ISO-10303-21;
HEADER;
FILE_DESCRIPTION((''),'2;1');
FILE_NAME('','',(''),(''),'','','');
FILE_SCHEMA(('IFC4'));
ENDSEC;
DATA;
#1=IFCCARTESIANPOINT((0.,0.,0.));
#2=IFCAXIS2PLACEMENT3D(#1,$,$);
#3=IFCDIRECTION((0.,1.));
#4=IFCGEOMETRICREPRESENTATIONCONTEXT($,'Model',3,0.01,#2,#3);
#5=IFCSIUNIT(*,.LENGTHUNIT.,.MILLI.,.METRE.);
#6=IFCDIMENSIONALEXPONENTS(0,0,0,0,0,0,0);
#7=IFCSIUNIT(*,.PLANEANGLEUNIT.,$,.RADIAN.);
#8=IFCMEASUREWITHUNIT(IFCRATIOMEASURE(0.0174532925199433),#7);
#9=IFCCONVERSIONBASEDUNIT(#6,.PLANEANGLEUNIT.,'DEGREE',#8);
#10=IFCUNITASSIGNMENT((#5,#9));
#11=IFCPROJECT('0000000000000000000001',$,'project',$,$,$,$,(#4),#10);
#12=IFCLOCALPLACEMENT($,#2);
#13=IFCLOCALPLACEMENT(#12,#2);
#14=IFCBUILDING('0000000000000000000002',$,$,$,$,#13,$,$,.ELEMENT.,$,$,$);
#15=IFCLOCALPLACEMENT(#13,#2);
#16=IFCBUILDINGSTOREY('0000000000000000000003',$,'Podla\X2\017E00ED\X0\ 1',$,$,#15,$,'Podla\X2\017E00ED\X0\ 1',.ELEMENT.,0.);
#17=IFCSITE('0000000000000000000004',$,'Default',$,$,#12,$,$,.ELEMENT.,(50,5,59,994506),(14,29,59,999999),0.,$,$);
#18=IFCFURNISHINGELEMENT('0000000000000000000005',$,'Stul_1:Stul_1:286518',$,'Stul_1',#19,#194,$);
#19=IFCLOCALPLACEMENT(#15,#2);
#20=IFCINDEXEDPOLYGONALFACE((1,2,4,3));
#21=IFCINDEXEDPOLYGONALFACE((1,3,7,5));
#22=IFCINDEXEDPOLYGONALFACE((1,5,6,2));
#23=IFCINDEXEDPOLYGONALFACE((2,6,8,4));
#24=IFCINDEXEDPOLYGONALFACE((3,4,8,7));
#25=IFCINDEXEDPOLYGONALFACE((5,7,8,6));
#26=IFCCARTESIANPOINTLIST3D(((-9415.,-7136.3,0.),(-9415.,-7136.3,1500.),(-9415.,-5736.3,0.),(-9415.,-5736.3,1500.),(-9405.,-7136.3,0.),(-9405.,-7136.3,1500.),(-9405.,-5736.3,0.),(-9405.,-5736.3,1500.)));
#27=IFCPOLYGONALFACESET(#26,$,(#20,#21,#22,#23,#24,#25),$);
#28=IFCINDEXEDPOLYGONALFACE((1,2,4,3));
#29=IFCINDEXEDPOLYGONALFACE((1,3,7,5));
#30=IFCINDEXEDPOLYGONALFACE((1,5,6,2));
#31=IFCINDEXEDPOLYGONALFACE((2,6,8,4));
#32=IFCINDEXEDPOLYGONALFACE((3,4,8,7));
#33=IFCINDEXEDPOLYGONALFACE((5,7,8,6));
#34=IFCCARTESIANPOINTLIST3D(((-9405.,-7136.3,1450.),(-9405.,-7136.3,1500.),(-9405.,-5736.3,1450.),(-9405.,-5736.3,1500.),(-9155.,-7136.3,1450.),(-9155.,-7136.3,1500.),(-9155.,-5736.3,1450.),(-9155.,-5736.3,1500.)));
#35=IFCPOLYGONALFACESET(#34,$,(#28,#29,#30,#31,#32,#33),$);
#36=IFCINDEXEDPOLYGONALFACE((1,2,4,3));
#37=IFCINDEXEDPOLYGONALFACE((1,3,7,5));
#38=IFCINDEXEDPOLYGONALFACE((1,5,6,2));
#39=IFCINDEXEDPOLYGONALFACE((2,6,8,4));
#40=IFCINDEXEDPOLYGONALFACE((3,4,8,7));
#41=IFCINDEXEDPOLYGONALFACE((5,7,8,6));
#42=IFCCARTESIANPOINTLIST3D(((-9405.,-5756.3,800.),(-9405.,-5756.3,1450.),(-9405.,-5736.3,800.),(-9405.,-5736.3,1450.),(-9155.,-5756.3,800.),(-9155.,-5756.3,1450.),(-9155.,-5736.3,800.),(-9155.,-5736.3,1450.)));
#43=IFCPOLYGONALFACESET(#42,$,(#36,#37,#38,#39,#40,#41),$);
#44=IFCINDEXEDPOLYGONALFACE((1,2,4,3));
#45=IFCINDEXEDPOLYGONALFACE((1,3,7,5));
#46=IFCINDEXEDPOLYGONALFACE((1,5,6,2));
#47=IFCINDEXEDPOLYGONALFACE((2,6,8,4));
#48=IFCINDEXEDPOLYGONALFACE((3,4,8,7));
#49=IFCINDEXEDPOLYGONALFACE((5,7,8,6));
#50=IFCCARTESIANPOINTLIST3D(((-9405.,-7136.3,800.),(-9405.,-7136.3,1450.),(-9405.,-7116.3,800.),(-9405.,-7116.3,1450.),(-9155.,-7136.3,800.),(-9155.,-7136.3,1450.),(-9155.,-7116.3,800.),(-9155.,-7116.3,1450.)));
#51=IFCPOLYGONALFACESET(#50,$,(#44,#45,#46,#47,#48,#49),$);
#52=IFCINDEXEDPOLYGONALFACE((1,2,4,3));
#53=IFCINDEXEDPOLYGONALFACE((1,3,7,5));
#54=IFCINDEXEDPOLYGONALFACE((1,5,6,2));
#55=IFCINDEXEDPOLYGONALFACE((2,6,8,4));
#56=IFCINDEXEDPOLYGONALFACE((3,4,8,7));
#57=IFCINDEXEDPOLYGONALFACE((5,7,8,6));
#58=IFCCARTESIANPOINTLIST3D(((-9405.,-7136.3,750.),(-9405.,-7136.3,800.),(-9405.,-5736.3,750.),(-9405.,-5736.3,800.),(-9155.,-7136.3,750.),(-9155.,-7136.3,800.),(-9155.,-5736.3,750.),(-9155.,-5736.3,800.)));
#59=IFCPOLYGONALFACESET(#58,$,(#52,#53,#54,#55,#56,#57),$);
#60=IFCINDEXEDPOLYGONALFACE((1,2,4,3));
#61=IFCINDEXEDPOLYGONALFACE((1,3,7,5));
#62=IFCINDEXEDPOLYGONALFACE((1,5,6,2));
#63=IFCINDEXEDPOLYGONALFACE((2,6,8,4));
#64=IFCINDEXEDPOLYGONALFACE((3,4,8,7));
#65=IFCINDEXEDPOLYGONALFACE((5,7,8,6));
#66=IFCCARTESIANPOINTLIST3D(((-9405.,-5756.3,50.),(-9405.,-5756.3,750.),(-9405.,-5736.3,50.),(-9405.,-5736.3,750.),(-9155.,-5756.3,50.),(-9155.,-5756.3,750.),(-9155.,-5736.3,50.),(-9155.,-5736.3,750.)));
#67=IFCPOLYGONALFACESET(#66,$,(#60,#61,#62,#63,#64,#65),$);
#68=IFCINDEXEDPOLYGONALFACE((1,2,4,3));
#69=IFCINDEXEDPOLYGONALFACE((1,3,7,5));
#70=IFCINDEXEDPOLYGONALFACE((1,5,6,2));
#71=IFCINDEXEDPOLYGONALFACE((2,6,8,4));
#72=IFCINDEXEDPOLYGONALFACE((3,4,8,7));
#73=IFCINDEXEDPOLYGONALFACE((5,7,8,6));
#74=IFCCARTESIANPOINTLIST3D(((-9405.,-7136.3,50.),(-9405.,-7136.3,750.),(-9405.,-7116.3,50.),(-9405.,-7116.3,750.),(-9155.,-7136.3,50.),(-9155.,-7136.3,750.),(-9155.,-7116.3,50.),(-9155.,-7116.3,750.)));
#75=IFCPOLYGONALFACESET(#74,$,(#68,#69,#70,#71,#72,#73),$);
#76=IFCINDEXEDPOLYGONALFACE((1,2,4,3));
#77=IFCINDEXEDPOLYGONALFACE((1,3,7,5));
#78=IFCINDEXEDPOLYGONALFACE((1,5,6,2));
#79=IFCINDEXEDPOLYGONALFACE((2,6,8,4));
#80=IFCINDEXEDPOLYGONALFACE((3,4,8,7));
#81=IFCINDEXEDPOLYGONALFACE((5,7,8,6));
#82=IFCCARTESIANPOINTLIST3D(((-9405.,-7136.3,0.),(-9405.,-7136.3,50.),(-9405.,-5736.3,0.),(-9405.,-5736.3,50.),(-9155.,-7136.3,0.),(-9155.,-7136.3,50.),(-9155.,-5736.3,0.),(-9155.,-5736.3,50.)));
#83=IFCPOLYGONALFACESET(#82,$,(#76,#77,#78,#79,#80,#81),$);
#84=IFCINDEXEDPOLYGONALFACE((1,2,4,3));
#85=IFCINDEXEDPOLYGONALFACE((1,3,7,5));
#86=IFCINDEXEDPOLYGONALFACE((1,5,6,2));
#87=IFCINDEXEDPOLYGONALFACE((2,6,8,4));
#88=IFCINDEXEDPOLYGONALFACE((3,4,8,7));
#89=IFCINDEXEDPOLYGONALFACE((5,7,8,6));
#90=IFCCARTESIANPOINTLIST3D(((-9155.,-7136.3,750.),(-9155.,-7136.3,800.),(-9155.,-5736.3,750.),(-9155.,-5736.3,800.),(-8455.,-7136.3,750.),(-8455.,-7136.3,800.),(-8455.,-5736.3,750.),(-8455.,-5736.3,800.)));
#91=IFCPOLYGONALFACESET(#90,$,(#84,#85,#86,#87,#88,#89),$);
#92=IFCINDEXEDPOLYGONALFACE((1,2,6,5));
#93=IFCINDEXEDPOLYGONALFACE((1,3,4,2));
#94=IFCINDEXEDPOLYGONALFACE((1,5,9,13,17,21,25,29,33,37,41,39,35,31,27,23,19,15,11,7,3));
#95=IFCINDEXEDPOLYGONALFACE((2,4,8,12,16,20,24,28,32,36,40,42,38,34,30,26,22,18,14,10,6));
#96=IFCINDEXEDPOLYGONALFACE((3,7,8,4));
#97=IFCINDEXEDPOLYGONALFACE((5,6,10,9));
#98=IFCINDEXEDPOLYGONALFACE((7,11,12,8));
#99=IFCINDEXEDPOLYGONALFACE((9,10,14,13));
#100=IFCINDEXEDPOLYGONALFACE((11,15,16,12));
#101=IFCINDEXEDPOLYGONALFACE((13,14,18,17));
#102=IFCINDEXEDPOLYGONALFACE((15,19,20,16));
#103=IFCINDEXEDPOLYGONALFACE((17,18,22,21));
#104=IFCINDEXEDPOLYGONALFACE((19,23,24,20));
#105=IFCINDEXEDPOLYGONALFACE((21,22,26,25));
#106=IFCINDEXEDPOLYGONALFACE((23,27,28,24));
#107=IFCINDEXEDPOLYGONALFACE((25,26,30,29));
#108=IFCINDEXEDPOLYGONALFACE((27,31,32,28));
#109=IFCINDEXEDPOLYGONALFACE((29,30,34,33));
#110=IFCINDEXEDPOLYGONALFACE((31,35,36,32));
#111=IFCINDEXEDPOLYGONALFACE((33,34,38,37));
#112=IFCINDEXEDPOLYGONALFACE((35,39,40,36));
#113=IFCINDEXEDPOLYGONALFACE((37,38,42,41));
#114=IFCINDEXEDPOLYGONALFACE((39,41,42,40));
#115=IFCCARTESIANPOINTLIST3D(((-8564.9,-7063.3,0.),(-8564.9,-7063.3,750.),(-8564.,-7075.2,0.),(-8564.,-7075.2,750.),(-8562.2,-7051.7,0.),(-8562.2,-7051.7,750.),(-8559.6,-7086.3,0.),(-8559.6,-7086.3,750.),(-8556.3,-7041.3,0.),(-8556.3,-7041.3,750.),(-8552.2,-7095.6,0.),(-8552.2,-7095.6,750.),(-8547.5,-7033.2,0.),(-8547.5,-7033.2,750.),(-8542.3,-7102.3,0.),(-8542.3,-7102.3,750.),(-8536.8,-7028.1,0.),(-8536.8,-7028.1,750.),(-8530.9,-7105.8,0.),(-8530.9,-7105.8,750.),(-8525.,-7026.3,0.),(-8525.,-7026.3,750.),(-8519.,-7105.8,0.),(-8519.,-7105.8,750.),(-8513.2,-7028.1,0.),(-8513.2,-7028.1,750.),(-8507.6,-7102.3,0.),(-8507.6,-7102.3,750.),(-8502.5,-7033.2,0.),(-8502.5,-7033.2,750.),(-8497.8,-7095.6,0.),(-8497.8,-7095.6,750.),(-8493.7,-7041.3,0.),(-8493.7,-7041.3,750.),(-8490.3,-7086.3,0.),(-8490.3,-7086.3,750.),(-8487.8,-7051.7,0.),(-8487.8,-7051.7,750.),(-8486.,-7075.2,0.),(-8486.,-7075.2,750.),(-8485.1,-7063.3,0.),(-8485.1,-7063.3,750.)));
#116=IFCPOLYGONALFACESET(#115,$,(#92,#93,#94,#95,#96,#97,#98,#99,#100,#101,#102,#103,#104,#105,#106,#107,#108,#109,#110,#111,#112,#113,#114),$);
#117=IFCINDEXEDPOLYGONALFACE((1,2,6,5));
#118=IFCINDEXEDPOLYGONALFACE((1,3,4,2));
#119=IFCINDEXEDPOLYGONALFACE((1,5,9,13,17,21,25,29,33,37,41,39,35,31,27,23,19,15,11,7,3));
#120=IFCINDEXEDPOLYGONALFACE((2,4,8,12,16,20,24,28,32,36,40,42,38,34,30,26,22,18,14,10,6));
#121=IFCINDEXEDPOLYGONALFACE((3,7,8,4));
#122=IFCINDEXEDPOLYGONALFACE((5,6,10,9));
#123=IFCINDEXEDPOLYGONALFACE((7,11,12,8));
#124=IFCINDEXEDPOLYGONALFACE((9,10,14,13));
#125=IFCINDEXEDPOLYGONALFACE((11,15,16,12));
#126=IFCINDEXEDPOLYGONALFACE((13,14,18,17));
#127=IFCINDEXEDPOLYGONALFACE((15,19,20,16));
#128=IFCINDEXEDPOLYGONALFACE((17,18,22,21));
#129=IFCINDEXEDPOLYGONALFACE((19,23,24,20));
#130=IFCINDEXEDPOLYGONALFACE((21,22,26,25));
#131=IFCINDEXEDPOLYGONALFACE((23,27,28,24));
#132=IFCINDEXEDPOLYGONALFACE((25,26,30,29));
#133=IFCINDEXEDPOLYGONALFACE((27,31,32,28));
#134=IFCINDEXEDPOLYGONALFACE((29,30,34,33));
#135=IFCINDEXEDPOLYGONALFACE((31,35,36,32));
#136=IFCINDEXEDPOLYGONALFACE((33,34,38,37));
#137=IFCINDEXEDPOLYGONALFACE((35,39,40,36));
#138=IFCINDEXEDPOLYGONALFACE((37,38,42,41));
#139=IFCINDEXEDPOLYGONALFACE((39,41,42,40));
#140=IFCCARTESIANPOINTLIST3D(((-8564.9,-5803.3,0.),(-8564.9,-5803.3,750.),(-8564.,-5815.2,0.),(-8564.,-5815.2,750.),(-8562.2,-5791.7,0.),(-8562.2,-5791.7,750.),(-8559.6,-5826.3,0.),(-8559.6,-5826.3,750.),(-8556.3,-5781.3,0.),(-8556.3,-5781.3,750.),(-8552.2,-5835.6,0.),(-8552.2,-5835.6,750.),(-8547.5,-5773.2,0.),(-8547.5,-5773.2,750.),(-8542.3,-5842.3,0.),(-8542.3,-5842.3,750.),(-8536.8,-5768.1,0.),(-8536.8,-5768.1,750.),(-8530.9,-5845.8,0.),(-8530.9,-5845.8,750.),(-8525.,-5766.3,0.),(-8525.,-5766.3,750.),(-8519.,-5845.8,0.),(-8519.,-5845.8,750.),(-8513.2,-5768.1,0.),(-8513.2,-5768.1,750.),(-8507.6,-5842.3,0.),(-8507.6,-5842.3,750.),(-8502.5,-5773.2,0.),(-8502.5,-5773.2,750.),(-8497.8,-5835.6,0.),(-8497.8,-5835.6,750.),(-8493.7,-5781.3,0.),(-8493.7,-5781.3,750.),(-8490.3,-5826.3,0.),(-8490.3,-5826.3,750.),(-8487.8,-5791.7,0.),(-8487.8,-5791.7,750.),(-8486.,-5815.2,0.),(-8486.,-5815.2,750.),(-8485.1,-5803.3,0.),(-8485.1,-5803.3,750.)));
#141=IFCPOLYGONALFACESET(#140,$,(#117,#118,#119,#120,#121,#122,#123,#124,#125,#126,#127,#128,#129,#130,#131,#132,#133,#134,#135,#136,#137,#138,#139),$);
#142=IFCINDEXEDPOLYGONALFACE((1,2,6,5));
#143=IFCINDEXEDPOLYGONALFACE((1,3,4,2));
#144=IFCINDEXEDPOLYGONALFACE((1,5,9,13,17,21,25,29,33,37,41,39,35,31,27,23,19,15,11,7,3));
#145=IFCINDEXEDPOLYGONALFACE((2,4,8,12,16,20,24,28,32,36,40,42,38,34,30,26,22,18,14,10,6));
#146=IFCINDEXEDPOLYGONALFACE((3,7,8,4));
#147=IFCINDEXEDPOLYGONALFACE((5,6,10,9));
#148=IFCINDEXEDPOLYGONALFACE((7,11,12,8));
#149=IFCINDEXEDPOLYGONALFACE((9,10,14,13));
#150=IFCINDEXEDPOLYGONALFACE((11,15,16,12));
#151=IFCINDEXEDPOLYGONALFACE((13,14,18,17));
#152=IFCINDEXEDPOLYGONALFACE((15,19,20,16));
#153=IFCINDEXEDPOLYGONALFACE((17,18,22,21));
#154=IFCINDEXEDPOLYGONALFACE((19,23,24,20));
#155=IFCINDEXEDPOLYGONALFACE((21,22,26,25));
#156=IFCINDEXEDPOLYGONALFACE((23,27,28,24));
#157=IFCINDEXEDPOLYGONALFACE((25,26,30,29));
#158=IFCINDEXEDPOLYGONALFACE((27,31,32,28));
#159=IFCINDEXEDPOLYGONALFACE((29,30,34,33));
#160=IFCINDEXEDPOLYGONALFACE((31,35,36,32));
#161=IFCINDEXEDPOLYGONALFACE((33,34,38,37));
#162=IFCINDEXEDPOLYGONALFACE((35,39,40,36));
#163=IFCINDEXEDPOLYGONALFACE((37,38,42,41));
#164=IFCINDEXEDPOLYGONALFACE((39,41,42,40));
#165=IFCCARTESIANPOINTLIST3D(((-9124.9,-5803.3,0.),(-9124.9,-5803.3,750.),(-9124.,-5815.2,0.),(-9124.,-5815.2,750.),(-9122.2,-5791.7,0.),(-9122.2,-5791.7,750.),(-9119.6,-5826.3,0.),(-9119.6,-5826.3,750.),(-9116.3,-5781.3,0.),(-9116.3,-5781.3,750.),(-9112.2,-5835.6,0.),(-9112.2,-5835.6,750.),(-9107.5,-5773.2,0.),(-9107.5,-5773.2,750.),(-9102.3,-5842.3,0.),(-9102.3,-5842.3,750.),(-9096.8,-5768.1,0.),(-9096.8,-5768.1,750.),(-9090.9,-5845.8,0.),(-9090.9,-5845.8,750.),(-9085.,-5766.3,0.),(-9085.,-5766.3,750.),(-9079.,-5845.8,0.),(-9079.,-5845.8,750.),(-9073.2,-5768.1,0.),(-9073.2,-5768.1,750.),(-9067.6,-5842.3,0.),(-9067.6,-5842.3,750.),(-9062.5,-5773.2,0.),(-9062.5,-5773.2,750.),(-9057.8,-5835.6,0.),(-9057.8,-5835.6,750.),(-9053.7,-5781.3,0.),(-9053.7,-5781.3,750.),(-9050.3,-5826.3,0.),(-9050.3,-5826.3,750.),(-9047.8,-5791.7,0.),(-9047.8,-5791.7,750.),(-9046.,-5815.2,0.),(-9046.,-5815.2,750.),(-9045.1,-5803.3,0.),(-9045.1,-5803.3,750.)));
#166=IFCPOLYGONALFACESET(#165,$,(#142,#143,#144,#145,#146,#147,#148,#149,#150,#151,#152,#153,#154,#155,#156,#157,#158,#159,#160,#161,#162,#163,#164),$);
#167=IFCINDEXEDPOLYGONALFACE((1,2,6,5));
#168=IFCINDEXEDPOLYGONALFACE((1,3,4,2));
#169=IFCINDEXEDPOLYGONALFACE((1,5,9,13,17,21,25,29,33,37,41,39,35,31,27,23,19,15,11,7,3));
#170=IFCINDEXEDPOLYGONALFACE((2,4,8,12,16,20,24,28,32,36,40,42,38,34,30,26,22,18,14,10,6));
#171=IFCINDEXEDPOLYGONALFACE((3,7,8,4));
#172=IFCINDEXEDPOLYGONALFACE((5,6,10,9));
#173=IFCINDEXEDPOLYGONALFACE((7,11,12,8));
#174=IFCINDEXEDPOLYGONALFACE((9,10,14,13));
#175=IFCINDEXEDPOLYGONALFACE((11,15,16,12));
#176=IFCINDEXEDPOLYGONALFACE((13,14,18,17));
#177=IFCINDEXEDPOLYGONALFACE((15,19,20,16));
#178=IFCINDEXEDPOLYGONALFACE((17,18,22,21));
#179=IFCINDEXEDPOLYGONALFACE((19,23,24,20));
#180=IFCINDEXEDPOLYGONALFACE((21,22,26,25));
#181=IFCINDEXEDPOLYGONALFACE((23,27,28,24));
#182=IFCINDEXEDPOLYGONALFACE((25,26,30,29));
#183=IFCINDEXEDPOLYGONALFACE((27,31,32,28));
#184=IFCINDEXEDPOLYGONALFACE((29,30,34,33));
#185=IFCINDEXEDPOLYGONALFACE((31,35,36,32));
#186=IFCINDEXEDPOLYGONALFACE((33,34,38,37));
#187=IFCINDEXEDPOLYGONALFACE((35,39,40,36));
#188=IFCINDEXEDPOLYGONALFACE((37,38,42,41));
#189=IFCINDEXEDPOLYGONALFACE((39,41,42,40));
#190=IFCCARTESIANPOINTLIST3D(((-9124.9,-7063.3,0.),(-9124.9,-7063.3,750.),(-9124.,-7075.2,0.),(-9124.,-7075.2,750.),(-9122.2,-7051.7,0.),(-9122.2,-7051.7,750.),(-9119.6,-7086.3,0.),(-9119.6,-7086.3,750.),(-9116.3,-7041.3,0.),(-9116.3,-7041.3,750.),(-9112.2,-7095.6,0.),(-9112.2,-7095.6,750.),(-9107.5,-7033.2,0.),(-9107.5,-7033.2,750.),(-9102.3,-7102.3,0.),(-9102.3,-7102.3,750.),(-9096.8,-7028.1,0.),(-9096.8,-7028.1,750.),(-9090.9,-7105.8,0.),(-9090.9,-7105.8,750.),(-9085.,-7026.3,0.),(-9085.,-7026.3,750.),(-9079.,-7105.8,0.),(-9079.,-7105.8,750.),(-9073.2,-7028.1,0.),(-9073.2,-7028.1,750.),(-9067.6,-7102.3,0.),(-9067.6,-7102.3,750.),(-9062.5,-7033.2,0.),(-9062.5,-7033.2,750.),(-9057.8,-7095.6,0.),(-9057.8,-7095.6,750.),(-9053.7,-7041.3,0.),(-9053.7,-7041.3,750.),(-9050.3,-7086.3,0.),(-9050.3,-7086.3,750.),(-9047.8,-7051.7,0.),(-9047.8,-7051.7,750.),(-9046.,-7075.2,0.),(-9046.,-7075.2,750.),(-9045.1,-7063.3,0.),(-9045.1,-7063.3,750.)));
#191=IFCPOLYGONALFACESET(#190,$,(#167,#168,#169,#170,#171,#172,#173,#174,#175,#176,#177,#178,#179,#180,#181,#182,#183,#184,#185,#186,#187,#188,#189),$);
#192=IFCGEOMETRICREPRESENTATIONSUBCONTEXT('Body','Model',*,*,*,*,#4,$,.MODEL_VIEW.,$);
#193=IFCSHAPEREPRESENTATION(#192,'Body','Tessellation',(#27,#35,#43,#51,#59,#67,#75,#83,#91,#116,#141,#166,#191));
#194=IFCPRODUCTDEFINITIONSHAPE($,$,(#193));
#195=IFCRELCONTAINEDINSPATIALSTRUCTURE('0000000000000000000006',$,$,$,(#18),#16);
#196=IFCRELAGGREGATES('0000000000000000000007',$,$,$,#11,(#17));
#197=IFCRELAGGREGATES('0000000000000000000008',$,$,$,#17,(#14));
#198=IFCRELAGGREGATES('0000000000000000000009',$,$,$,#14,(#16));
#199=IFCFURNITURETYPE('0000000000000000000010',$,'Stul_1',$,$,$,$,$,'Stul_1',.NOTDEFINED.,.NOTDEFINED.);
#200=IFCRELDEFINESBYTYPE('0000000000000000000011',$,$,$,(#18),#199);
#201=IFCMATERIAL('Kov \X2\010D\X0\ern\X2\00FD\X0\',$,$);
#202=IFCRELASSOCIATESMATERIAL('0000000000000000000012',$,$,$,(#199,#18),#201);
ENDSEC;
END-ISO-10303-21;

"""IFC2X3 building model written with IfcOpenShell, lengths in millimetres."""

from ifc_helpers import new_model, entity, si_unit, converted_unit, direction, frame, frame_2d, origin, origin_2d_with_axis, place, context, subcontext, project, spatial, rectangle, circle, extrude, source, transform, mapped, material, type_object, type_shapes, element, save


model = new_model("IFC2X3")

# Units and contexts
model_context = context("Model", 3, precision=0.01, world=origin(), true_north=direction((0.0, 1.0)))
body_context = subcontext(model_context, "Body", "Model", "MODEL_VIEW")
ifc_project = project(units=[si_unit("LENGTHUNIT", "METRE", prefix="MILLI"), converted_unit("PLANEANGLEUNIT", "DEGREE", entity("IfcRatioMeasure", 0.0174532925199433), si_unit("PLANEANGLEUNIT", "RADIAN"), dimensions=[0, 0, 0, 0, 0, 0, 0])], contexts=[model_context])

# Site, building, storey
site_placement = place(None, origin())
site = spatial("IfcSite", under=ifc_project, at=site_placement, Name="Default", CompositionType="ELEMENT", RefLatitude=(50, 5, 59, 994506), RefLongitude=(14, 29, 59, 999999), RefElevation=0.0)
building_placement = place(site_placement, origin())
building = spatial("IfcBuilding", under=site, at=building_placement, CompositionType="ELEMENT")
storey_placement = place(building_placement, origin())
storey = spatial("IfcBuildingStorey", under=building, at=storey_placement, Name="Podlaží 1", LongName="Podlaží 1", CompositionType="ELEMENT", Elevation=0.0)

# Furnishing element
ifc_material_1 = material(Name="Kov černý")
furniture_type = type_object("IfcFurnitureType", Name="Stul_1", ElementType="Stul_1", material=ifc_material_1)
shared_shape_1 = source(origin(), body_context, "Body", "SweptSolid", [
    extrude(rectangle(XDim=1400.0, YDim=10.0, at=origin_2d_with_axis()), frame((0.0, 605.0, 0.0), z_axis=(0.0, 0.0, 1.0), x_axis=(-1.0, 0.0, 0.0)), (0.0, 0.0, 1.0), 1500.0),
    extrude(rectangle(XDim=1400.0, YDim=250.0, at=frame_2d((0.0, 0.0), x_axis=(1.0, 0.0))), frame((0.0, 475.0, 1450.0), z_axis=(0.0, 0.0, 1.0), x_axis=(-1.0, 0.0, 0.0)), (0.0, 0.0, 1.0), 50.0),
    extrude(rectangle(XDim=20.0, YDim=250.0, at=origin_2d_with_axis()), frame((690.0, 475.0, 800.0), z_axis=(0.0, 0.0, 1.0), x_axis=(-1.0, 0.0, 0.0)), (0.0, 0.0, 1.0), 650.0),
    extrude(rectangle(XDim=20.0, YDim=250.0, at=frame_2d((0.0, 0.0), x_axis=(1.0, 0.0))), frame((-690.0, 475.0, 800.0), z_axis=(0.0, 0.0, 1.0), x_axis=(-1.0, 0.0, 0.0)), (0.0, 0.0, 1.0), 650.0),
    extrude(rectangle(XDim=1400.0, YDim=250.0, at=origin_2d_with_axis()), frame((0.0, 475.0, 750.0), z_axis=(0.0, 0.0, 1.0), x_axis=(-1.0, 0.0, 0.0)), (0.0, 0.0, 1.0), 50.0),
    extrude(rectangle(XDim=20.0, YDim=250.0, at=origin_2d_with_axis()), frame((690.0, 475.0, 50.0), z_axis=(0.0, 0.0, 1.0), x_axis=(-1.0, 0.0, 0.0)), (0.0, 0.0, 1.0), 700.0),
    extrude(rectangle(XDim=20.0, YDim=250.0, at=frame_2d((0.0, 0.0), x_axis=(1.0, 0.0))), frame((-690.0, 475.0, 50.0), z_axis=(0.0, 0.0, 1.0), x_axis=(-1.0, 0.0, 0.0)), (0.0, 0.0, 1.0), 700.0),
    extrude(rectangle(XDim=1400.0, YDim=250.0, at=origin_2d_with_axis()), frame((0.0, 475.0, 0.0), z_axis=(0.0, 0.0, 1.0), x_axis=(-1.0, 0.0, 0.0)), (0.0, 0.0, 1.0), 50.0),
    extrude(rectangle(XDim=1400.0, YDim=700.0, at=origin_2d_with_axis()), frame((0.0, 0.0, 750.0), z_axis=(0.0, 0.0, 1.0), x_axis=(-1.0, 0.0, 0.0)), (0.0, 0.0, 1.0), 50.0),
    extrude(circle(Radius=40.0, at=frame_2d((0.0, 0.0), x_axis=(1.0, 0.0))), frame((-630.0, -280.0, 0.0)), (0.0, 0.0, 1.0), 750.0),
    extrude(circle(Radius=40.0, at=frame_2d((0.0, 0.0), x_axis=(1.0, 0.0))), frame((630.0, -280.0, 0.0)), (0.0, 0.0, 1.0), 750.0),
    extrude(circle(Radius=40.0, at=frame_2d((0.0, 0.0), x_axis=(1.0, 0.0))), frame((630.0, 280.0, 0.0)), (0.0, 0.0, 1.0), 750.0),
    extrude(circle(Radius=40.0, at=frame_2d((0.0, 0.0), x_axis=(1.0, 0.0))), frame((-630.0, 280.0, 0.0)), (0.0, 0.0, 1.0), 750.0),
])
type_shapes(furniture_type, [shared_shape_1])
for number, where, z_axis, x_axis, name in (
    (1, (-8805.0, -6436.3, 0.0), (0.0, 0.0, 1.0), (0.0, 1.0, 0.0), "Stul_1:Stul_1:286518"),
):
    element("IfcFurnishingElement", number, at=place(storey_placement, frame(where, z_axis=z_axis, x_axis=x_axis)), inside=storey, type_object=furniture_type, material=ifc_material_1, Name=name, ObjectType="Stul_1", context=body_context, shape_type="MappedRepresentation", body=[
        mapped(shared_shape_1, transform((0.0, 0.0, 0.0), scale=1.0)),
    ])

save(model, "model.ifc")
